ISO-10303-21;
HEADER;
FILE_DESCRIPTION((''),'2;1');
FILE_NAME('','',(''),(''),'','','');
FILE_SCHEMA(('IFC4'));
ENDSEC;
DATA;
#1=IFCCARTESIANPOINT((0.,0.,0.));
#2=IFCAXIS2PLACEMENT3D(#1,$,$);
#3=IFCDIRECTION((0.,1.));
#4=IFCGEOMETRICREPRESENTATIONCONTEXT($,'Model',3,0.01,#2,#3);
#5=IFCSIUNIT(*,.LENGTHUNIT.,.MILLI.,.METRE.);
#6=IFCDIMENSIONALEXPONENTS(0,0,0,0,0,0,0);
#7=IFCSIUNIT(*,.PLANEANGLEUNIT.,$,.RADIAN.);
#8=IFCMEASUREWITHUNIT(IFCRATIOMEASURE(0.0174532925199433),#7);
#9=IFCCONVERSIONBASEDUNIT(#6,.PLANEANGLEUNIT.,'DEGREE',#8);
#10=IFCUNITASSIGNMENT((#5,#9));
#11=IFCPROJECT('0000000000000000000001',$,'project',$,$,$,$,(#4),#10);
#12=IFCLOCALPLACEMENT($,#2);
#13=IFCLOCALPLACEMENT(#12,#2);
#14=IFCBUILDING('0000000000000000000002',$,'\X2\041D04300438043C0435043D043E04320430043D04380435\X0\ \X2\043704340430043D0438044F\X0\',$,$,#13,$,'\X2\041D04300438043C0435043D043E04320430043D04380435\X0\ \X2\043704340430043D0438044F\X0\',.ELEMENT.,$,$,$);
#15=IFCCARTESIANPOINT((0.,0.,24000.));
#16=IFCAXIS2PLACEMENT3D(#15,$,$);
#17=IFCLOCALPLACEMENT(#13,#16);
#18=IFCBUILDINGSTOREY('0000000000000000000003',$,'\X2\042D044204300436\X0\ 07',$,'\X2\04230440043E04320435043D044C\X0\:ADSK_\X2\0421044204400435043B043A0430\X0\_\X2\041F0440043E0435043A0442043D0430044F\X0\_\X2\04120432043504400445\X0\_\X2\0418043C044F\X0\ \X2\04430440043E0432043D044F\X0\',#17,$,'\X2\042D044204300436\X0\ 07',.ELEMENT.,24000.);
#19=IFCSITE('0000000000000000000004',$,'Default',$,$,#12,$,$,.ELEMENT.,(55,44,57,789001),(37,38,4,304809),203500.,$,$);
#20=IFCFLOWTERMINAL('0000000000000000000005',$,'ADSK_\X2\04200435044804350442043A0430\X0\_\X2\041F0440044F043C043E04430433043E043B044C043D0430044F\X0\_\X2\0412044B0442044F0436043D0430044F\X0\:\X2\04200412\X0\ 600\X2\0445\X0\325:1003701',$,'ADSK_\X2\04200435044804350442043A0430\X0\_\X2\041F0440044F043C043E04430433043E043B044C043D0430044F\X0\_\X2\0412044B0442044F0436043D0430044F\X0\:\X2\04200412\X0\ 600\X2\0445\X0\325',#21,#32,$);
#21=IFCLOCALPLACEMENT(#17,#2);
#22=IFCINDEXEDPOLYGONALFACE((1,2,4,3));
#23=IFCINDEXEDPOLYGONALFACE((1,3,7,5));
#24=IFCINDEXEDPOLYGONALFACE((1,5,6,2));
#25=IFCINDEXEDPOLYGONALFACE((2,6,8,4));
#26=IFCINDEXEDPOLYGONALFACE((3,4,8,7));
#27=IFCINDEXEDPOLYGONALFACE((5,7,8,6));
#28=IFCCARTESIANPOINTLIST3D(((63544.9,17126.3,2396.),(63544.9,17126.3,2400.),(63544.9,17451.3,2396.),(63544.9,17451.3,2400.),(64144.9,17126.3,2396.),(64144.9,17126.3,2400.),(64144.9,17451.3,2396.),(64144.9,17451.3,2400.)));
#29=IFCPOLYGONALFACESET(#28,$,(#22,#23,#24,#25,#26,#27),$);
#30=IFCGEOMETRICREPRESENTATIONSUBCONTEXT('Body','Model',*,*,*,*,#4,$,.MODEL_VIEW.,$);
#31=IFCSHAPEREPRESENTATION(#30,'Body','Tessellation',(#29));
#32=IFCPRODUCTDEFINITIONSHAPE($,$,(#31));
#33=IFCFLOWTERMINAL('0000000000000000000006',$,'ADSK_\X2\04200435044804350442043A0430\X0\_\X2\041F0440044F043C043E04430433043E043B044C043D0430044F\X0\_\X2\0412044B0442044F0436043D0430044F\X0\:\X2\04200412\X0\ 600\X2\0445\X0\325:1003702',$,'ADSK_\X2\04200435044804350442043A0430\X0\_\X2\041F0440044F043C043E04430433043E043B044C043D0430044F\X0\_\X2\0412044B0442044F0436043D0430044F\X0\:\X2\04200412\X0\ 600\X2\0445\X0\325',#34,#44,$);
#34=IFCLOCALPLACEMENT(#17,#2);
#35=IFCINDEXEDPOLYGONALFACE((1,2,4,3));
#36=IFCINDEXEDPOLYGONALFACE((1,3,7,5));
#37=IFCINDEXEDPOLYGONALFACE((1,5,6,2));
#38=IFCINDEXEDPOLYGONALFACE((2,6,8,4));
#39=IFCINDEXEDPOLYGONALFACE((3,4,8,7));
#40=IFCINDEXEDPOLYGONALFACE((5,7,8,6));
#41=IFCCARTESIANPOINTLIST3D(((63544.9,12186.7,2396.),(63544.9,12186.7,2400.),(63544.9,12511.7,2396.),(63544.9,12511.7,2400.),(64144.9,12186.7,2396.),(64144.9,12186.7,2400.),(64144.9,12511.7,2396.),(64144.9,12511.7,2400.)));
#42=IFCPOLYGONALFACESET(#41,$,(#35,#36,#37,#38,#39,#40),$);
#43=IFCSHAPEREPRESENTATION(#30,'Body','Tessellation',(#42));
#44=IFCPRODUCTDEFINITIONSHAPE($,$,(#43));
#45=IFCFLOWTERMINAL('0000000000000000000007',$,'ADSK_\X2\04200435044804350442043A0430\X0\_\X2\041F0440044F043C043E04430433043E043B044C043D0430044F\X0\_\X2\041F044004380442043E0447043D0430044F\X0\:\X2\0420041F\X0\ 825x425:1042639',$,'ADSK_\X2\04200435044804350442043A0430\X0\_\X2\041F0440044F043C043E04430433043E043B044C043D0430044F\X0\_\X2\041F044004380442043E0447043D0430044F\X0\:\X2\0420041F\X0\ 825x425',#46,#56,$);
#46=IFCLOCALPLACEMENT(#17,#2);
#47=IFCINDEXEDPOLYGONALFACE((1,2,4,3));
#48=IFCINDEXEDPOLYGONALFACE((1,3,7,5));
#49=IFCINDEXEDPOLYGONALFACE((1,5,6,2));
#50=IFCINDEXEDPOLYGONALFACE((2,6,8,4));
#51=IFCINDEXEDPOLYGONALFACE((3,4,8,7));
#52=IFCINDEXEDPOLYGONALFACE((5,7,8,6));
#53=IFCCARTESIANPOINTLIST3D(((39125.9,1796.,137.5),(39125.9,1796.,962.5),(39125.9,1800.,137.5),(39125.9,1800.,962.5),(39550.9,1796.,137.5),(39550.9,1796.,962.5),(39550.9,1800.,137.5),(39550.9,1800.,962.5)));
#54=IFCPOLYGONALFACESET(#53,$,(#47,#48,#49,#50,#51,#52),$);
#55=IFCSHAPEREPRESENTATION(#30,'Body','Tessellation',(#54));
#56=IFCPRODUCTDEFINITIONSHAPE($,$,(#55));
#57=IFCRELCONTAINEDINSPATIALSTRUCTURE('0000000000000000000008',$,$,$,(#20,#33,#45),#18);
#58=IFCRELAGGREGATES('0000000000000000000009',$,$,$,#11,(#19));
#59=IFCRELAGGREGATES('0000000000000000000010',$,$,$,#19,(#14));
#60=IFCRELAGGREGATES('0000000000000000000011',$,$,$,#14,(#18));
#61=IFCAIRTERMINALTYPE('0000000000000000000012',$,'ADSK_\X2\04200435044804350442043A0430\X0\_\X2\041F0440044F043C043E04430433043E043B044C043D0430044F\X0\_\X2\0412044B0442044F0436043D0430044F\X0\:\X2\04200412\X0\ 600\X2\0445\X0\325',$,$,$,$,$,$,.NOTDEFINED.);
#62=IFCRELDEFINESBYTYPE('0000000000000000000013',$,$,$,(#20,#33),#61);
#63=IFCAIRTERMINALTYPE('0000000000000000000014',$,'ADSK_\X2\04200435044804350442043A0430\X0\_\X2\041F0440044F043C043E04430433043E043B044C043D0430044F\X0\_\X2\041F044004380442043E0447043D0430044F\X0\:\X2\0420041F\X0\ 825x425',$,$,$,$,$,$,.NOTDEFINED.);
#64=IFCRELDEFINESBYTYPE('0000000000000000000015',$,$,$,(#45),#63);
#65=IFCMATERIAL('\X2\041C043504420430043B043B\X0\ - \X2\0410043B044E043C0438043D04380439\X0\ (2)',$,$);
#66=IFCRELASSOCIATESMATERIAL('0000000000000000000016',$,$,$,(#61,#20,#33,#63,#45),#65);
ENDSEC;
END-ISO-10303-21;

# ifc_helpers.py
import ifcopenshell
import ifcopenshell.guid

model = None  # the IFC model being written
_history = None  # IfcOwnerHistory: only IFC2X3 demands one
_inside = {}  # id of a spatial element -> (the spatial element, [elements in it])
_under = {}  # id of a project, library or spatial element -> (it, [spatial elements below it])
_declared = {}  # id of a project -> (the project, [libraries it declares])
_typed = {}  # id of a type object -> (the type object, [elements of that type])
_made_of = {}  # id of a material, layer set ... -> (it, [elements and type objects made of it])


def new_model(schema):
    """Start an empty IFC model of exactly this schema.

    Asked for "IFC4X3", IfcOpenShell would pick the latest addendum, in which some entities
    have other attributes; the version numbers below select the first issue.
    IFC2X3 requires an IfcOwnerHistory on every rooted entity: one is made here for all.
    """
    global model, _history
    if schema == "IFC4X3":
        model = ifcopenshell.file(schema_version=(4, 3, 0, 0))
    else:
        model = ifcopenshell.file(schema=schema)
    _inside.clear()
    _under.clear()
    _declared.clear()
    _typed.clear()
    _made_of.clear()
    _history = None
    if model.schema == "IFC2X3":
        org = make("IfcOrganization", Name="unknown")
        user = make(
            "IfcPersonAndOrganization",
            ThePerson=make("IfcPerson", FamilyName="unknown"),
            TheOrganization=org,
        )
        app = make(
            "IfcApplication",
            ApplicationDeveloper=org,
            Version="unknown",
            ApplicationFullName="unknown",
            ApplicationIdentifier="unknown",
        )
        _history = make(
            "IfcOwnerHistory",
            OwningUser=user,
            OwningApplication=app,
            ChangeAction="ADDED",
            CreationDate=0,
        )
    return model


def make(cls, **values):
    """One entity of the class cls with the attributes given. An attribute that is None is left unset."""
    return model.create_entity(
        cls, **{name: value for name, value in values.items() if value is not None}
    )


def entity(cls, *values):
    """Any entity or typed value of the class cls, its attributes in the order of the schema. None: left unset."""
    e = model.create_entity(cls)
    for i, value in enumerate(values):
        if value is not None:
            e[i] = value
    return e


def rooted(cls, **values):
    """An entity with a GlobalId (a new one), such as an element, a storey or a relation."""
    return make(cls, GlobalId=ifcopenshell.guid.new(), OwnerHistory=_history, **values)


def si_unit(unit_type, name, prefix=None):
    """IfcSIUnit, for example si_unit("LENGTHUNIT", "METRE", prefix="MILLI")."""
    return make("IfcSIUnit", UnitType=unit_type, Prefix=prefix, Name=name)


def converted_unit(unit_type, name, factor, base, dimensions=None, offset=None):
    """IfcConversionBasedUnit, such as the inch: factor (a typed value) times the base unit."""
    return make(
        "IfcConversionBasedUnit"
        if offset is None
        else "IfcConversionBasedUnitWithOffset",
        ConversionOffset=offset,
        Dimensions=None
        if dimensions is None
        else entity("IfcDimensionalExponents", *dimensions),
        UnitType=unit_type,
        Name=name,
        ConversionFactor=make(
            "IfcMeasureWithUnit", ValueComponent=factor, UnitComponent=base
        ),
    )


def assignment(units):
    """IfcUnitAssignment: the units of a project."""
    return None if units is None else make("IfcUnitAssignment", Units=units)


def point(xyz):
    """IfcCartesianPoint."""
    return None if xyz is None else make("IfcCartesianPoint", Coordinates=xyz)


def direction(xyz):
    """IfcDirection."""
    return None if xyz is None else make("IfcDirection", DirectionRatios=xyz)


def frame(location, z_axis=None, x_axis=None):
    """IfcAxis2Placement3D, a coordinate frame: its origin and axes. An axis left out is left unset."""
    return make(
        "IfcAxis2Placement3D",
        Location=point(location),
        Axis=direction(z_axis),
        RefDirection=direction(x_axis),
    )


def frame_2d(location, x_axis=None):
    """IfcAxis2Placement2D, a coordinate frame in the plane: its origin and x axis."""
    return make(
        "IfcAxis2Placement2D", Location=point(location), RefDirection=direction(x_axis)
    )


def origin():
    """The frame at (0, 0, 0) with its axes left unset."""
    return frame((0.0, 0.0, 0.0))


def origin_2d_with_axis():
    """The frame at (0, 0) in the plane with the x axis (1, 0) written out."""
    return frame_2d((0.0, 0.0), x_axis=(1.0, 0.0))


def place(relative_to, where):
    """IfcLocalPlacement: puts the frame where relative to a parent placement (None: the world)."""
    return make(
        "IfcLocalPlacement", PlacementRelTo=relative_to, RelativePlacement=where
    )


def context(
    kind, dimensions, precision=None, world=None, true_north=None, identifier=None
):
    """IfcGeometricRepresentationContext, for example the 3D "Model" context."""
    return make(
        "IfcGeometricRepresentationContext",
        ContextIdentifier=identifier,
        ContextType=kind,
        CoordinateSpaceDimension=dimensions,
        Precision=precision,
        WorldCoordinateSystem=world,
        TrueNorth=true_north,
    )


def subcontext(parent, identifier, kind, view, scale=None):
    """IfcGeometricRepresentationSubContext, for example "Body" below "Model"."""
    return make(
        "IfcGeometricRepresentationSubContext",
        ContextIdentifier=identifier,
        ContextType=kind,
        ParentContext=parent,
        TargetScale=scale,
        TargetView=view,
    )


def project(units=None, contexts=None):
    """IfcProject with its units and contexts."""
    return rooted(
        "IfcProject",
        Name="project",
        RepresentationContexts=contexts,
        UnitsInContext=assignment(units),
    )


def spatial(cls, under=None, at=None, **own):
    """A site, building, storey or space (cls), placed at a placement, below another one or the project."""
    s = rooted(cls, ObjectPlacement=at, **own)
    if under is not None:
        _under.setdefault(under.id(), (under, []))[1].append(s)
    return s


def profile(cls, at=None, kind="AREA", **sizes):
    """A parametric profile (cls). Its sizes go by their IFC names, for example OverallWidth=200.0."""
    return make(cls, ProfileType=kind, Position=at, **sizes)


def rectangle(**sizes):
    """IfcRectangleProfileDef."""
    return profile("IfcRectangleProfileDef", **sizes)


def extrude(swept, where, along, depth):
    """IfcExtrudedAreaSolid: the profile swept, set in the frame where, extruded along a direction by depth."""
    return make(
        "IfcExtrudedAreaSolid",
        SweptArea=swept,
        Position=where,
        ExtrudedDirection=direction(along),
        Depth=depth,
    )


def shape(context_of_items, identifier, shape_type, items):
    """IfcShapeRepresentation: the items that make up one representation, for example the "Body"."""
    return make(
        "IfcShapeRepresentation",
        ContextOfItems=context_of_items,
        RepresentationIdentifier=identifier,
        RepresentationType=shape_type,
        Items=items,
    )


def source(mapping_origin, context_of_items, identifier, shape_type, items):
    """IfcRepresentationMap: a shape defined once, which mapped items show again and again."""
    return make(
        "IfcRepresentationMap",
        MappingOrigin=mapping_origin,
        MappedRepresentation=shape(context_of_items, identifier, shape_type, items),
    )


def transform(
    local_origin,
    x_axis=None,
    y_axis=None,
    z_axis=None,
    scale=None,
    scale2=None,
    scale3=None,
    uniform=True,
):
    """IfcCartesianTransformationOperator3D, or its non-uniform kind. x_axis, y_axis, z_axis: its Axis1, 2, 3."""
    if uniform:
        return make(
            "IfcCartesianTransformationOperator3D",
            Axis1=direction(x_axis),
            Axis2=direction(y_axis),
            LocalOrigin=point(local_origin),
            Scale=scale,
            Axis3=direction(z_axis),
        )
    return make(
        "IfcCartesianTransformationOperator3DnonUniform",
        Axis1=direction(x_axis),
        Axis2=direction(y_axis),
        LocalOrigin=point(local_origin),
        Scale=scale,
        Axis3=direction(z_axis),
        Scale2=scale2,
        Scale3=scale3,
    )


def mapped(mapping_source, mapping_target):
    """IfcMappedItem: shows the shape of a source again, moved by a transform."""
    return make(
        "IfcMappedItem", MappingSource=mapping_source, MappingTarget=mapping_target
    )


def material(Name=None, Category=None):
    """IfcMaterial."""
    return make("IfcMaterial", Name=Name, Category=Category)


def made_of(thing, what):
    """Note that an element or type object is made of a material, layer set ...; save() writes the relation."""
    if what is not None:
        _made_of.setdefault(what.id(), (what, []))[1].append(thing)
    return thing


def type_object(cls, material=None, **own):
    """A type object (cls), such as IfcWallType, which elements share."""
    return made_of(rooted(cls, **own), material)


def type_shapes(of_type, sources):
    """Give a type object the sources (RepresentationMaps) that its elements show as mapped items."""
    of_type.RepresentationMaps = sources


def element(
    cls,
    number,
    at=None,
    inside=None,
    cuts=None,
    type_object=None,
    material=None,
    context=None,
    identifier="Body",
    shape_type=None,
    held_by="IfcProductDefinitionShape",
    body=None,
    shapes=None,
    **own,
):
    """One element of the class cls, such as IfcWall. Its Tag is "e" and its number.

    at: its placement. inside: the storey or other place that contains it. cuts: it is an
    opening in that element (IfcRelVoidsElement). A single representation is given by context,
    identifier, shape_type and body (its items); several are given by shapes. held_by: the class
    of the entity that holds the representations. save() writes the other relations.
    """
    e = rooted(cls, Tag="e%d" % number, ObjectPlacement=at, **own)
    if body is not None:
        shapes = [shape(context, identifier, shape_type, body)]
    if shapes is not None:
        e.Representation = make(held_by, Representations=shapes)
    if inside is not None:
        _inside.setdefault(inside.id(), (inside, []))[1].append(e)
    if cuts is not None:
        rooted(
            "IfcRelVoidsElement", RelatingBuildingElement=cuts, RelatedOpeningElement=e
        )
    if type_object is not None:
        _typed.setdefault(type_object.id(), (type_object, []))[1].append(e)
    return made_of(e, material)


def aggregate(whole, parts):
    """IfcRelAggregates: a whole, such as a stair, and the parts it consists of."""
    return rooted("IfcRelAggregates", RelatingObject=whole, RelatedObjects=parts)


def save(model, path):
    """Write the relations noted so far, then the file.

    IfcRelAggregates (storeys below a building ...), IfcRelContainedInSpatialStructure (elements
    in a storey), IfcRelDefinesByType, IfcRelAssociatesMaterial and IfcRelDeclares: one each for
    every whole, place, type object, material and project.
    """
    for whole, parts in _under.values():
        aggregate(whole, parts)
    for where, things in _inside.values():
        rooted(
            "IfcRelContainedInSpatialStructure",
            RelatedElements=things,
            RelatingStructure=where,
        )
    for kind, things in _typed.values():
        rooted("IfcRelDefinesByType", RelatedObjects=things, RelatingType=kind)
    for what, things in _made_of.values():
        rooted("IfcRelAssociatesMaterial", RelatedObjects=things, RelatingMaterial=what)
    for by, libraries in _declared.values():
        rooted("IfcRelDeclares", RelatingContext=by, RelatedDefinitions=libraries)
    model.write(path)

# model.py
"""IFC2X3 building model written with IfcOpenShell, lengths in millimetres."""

from ifc_helpers import new_model, entity, si_unit, converted_unit, direction, frame, origin, origin_2d_with_axis, place, context, subcontext, project, spatial, rectangle, extrude, source, transform, mapped, material, type_object, type_shapes, element, save


model = new_model("IFC2X3")

# Units and contexts
model_context = context("Model", 3, precision=0.01, world=origin(), true_north=direction((0.0, 1.0)))
body_context = subcontext(model_context, "Body", "Model", "MODEL_VIEW")
ifc_project = project(units=[si_unit("LENGTHUNIT", "METRE", prefix="MILLI"), converted_unit("PLANEANGLEUNIT", "DEGREE", entity("IfcRatioMeasure", 0.0174532925199433), si_unit("PLANEANGLEUNIT", "RADIAN"), dimensions=[0, 0, 0, 0, 0, 0, 0])], contexts=[model_context])

# Site, building, storey
site_placement = place(None, origin())
site = spatial("IfcSite", under=ifc_project, at=site_placement, Name="Default", CompositionType="ELEMENT", RefLatitude=(55, 44, 57, 789001), RefLongitude=(37, 38, 4, 304809), RefElevation=203500.0)
building_placement = place(site_placement, origin())
building = spatial("IfcBuilding", under=site, at=building_placement, Name="Наименование здания", LongName="Наименование здания", CompositionType="ELEMENT")
storey_placement = place(building_placement, frame((0.0, 0.0, 24000.0)))
storey = spatial("IfcBuildingStorey", under=building, at=storey_placement, Name="Этаж 07", ObjectType="Уровень:ADSK_Стрелка_Проектная_Вверх_Имя уровня", LongName="Этаж 07", CompositionType="ELEMENT", Elevation=24000.0)

# Shared definitions
ifc_material_1 = material(Name="Металл - Алюминий (2)")

# Flow terminals
air_terminal_type_1 = type_object("IfcAirTerminalType", Name="ADSK_Решетка_Прямоугольная_Вытяжная:РВ 600х325", PredefinedType="NOTDEFINED", material=ifc_material_1)
shared_shape_1 = source(origin(), body_context, "Body", "SweptSolid", [
    extrude(rectangle(XDim=4.0, YDim=600.0, at=origin_2d_with_axis()), frame((0.0, -2.0, -162.5), z_axis=(0.0, 0.0, 1.0), x_axis=(0.0, 1.0, 0.0)), (0.0, 0.0, 1.0), 325.0),
])
type_shapes(air_terminal_type_1, [shared_shape_1])
for number, where, z_axis, x_axis, name in (
    (1, (63844.9, 17288.8, 2400.0), (0.0, -1.0, 0.0), (1.0, 0.0, 0.0), "ADSK_Решетка_Прямоугольная_Вытяжная:РВ 600х325:1003701"),
    (2, (63844.9, 12349.2, 2400.0), (0.0, -1.0, 0.0), (1.0, 0.0, 0.0), "ADSK_Решетка_Прямоугольная_Вытяжная:РВ 600х325:1003702"),
):
    element("IfcFlowTerminal", number, at=place(storey_placement, frame(where, z_axis=z_axis, x_axis=x_axis)), inside=storey, type_object=air_terminal_type_1, material=ifc_material_1, Name=name, ObjectType="ADSK_Решетка_Прямоугольная_Вытяжная:РВ 600х325", context=body_context, shape_type="MappedRepresentation", body=[
        mapped(shared_shape_1, transform((0.0, 0.0, 0.0), scale=1.0)),
    ])
air_terminal_type_2 = type_object("IfcAirTerminalType", Name="ADSK_Решетка_Прямоугольная_Приточная:РП 825x425", PredefinedType="NOTDEFINED", material=ifc_material_1)
shared_shape_2 = source(origin(), body_context, "Body", "SweptSolid", [
    extrude(rectangle(XDim=4.0, YDim=825.0, at=origin_2d_with_axis()), frame((0.0, -2.0, -212.5), z_axis=(0.0, 0.0, 1.0), x_axis=(0.0, 1.0, 0.0)), (0.0, 0.0, 1.0), 425.0),
])
type_shapes(air_terminal_type_2, [shared_shape_2])
flow_terminal_1_placement = place(storey_placement, frame((39338.4, 1800.0, 550.0), z_axis=(1.0, 0.0, 0.0), x_axis=(0.0, 0.0, -1.0)))
element("IfcFlowTerminal", 3, at=flow_terminal_1_placement, inside=storey, type_object=air_terminal_type_2, material=ifc_material_1, Name="ADSK_Решетка_Прямоугольная_Приточная:РП 825x425:1042639", ObjectType="ADSK_Решетка_Прямоугольная_Приточная:РП 825x425", context=body_context, shape_type="MappedRepresentation", body=[
    mapped(shared_shape_2, transform((0.0, 0.0, 0.0), scale=1.0)),
])

save(model, "model.ifc")
